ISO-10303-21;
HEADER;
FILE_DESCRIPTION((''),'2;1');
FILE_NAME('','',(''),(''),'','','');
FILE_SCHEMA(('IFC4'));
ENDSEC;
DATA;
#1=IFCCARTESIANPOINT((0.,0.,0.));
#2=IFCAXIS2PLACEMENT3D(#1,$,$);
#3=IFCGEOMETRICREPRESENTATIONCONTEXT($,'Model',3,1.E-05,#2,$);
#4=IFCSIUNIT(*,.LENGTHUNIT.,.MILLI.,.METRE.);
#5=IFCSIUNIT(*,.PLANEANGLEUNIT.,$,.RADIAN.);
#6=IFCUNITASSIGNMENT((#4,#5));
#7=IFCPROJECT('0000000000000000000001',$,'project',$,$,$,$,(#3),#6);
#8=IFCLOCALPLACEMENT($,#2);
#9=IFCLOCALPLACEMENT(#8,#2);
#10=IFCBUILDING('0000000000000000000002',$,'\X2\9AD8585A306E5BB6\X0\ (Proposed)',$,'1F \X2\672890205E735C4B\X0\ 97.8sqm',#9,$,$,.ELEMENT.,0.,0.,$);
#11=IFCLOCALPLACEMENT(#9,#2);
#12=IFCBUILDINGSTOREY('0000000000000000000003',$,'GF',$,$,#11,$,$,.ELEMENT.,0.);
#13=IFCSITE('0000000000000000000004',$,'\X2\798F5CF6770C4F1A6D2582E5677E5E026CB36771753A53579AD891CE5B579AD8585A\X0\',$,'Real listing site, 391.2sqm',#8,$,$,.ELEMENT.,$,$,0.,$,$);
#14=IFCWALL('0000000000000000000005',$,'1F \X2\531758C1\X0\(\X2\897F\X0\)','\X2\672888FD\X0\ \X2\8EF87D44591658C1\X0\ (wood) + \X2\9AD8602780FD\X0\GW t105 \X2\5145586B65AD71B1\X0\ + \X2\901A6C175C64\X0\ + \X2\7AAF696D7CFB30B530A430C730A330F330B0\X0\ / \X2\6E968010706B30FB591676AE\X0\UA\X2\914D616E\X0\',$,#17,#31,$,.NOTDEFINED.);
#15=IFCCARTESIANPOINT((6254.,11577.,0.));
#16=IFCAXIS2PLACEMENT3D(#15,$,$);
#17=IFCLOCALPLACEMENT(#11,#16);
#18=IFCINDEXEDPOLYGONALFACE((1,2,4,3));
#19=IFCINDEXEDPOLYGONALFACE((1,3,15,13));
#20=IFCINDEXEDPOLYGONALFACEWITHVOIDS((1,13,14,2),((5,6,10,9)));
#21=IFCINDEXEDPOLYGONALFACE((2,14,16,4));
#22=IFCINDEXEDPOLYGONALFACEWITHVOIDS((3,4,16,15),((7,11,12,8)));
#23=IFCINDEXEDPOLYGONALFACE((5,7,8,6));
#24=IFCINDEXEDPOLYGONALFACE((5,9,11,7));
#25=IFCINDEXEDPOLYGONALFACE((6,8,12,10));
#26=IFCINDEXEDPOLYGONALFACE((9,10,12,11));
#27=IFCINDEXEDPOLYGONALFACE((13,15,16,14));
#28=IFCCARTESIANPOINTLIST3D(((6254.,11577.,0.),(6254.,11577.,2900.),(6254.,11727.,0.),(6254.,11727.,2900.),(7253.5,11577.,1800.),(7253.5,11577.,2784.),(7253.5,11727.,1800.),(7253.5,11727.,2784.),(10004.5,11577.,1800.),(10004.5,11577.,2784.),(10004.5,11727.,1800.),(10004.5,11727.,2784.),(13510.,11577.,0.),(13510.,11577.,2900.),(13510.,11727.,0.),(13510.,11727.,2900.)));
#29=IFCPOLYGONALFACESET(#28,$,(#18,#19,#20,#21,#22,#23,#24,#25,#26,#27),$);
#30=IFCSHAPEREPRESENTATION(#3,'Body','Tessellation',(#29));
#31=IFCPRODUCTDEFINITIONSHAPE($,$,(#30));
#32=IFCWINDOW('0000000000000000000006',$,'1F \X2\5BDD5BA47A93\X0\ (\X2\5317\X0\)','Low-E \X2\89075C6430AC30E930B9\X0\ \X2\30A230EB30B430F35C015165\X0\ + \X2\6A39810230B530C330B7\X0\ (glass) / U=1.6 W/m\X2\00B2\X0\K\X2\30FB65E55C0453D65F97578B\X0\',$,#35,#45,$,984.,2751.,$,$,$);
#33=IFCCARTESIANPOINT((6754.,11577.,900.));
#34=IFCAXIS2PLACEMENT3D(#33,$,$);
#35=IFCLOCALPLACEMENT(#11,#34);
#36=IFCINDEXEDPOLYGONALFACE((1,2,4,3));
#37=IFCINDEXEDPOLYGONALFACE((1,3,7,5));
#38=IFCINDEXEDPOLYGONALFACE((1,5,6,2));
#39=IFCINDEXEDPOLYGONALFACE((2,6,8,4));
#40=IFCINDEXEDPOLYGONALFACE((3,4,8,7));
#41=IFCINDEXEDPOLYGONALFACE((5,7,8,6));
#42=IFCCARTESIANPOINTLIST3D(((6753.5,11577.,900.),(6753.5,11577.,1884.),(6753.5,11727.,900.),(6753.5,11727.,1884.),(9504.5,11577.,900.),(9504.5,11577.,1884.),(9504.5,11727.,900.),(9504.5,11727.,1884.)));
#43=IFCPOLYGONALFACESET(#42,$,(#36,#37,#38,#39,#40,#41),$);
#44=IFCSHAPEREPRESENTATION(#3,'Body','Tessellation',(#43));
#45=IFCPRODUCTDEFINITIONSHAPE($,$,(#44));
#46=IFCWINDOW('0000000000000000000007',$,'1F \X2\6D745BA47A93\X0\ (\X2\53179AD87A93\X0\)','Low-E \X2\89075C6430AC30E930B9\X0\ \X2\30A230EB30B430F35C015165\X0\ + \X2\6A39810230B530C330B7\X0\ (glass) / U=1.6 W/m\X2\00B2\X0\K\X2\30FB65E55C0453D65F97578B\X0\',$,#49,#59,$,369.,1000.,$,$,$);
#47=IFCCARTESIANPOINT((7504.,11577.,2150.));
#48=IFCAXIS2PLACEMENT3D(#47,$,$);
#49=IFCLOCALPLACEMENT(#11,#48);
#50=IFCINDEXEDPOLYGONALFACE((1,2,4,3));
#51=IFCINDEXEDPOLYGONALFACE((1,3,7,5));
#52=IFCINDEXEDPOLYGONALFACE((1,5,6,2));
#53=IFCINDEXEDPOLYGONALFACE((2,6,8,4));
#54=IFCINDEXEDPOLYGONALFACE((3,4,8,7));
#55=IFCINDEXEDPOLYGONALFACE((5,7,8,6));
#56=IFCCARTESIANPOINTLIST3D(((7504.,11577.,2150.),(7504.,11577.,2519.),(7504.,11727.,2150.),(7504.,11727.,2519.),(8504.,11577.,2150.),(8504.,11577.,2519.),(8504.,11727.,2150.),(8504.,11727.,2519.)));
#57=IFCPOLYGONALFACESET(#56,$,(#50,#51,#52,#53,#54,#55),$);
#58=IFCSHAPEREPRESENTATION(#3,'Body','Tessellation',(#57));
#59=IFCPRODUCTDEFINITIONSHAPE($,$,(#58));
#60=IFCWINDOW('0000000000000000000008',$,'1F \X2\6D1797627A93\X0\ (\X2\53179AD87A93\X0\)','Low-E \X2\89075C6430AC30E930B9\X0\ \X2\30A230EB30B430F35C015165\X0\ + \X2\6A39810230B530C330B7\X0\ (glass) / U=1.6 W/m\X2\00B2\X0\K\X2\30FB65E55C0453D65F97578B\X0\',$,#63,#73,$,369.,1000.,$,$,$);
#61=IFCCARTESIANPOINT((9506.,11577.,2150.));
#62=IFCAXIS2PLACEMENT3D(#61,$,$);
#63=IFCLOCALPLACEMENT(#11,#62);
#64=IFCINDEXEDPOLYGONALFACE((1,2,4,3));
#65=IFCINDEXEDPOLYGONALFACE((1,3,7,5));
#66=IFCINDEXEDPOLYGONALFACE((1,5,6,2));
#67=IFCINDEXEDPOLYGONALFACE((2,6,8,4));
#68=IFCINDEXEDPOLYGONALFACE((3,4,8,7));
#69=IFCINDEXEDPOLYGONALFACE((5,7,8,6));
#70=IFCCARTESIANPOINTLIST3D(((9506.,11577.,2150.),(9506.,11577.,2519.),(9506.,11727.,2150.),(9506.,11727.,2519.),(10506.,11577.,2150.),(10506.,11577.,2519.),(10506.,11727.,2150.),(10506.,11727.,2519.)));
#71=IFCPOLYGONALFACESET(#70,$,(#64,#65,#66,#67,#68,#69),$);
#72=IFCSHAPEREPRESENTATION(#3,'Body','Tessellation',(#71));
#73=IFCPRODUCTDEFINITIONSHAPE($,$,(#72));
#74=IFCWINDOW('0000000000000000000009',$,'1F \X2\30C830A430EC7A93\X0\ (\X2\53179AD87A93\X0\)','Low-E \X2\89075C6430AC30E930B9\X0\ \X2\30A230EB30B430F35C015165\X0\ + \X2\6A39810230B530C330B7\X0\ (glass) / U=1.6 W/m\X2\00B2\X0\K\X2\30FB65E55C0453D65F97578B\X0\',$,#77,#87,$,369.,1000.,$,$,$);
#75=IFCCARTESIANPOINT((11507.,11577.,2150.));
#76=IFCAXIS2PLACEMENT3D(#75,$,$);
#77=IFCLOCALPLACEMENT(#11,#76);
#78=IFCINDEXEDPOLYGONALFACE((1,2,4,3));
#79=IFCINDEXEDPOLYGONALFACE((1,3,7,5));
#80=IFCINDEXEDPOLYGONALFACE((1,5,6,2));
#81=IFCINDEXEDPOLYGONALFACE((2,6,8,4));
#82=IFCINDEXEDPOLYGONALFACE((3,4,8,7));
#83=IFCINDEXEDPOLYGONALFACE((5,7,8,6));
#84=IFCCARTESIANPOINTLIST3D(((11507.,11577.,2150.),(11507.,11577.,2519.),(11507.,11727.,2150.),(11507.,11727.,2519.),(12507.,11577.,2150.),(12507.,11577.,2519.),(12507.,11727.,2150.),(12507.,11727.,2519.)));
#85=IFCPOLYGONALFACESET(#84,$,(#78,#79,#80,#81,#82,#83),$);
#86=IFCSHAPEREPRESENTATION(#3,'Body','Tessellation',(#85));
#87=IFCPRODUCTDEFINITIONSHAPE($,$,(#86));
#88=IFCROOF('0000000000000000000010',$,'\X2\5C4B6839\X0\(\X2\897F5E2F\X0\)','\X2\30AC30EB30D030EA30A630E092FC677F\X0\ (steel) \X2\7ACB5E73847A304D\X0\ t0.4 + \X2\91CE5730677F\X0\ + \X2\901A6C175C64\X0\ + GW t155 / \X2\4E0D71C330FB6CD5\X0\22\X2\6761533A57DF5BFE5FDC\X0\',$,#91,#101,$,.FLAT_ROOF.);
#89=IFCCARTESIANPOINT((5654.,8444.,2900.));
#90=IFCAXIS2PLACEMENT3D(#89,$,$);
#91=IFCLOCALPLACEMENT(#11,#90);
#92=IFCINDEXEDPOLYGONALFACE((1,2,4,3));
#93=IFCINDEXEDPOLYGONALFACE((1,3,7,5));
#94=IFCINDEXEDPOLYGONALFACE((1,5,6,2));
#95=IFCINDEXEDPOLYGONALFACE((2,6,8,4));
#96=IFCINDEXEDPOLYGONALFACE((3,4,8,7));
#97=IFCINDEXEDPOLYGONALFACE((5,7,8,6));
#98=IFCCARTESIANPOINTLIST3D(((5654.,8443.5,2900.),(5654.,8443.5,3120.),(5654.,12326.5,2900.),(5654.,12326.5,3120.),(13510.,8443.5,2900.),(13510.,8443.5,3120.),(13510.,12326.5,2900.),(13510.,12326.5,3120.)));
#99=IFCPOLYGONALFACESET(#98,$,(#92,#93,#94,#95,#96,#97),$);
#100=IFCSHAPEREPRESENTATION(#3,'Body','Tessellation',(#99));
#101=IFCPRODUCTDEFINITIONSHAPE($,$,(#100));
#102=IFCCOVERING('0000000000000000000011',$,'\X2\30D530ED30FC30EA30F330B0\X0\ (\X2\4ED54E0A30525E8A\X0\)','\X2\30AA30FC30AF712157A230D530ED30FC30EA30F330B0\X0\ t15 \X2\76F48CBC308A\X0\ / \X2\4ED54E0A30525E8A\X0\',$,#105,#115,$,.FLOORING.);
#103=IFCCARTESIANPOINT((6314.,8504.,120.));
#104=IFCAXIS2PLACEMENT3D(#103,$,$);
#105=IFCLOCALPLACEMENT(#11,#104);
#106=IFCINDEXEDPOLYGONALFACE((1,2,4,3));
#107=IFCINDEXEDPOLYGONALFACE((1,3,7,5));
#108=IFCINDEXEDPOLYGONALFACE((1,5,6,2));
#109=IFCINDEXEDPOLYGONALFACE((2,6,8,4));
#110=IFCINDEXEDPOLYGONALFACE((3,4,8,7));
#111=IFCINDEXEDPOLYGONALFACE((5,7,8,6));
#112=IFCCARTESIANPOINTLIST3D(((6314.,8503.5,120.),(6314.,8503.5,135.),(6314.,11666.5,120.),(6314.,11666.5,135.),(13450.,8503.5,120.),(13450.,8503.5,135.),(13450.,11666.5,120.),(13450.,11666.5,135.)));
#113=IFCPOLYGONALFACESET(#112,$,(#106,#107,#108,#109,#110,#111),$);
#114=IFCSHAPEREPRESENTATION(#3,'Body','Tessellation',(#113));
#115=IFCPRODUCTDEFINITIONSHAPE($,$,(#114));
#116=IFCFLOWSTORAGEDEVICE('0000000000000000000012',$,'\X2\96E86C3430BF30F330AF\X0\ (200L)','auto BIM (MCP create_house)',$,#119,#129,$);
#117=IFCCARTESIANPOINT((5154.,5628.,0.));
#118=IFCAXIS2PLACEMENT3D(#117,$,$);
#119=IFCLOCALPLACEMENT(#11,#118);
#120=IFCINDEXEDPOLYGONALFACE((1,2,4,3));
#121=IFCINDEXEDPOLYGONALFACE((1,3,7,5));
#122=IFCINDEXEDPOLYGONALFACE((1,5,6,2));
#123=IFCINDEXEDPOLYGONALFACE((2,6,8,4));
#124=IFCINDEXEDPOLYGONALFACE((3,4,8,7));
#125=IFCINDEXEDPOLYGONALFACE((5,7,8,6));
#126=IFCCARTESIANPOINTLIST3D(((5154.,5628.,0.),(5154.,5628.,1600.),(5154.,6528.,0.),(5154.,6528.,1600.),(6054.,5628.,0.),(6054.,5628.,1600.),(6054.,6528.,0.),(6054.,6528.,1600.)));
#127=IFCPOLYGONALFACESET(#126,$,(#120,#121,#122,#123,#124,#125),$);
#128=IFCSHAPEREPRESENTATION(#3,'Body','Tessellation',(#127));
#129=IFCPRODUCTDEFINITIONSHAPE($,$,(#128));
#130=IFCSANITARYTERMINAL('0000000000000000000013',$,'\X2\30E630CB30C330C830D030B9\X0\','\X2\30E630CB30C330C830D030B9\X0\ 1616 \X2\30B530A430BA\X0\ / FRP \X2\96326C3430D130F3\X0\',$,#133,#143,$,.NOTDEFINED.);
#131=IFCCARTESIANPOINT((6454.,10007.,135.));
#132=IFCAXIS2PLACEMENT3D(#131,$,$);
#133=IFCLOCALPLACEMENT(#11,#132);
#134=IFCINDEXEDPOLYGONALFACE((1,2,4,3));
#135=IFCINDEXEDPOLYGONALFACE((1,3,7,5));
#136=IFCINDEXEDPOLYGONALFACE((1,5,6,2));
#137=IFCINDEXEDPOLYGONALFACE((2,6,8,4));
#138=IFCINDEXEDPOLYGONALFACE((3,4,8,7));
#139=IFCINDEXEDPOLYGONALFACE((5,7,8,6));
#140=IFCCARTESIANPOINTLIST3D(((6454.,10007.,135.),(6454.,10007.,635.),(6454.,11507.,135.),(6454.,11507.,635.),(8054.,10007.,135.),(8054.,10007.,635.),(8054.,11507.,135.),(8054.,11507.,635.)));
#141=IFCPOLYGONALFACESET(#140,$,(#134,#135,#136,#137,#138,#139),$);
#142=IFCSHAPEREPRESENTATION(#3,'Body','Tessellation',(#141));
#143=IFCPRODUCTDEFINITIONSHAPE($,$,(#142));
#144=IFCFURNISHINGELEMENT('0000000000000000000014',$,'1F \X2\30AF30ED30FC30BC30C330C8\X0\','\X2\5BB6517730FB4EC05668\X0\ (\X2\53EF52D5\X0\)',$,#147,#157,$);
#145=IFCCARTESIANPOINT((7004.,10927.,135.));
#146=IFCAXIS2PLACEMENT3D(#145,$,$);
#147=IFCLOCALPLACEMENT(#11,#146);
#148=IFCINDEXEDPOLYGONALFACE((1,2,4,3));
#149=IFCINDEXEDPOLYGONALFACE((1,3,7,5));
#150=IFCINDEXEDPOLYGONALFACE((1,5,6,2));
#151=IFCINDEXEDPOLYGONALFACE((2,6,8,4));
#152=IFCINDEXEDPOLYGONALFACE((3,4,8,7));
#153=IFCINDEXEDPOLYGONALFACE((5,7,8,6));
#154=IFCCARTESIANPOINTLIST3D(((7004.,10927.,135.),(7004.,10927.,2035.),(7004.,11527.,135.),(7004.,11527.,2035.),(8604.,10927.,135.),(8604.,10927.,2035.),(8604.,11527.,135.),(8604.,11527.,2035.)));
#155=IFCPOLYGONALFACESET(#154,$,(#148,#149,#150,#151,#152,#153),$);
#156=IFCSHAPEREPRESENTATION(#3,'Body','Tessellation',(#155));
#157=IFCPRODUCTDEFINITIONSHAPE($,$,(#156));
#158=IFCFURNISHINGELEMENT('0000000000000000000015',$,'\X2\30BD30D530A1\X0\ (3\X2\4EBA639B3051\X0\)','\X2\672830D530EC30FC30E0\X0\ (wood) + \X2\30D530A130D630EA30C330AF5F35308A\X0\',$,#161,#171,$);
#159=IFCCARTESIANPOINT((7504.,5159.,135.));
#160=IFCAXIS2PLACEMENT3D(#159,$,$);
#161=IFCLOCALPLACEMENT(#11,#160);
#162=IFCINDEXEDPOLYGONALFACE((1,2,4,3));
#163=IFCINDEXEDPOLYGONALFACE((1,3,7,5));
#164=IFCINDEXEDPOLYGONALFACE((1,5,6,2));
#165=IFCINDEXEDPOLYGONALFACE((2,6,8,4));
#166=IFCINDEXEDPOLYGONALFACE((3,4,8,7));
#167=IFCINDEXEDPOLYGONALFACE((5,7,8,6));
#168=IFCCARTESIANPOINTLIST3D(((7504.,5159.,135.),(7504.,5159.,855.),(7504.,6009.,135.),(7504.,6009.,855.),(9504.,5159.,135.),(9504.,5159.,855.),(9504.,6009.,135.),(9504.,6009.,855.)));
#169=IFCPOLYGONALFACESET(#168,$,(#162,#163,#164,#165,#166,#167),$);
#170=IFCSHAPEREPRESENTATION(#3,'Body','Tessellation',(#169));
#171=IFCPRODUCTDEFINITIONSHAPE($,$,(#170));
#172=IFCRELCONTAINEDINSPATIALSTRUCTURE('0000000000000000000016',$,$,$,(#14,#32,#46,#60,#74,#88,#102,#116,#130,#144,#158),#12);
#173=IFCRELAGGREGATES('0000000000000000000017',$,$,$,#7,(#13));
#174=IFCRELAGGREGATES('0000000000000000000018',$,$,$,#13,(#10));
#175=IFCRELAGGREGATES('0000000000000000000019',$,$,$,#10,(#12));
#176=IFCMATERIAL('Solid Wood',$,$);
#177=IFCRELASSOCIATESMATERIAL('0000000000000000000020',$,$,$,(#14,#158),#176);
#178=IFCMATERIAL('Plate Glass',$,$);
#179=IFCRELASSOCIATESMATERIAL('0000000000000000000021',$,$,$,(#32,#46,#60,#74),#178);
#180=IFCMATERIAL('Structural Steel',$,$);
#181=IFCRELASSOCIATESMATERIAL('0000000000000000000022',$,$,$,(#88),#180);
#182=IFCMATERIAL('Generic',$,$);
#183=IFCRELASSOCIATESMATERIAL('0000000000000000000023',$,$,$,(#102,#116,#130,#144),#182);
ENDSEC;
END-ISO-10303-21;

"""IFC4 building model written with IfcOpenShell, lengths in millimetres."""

from ifc_helpers import new_model, si_unit, frame, frame_2d, origin, place, context, project, spatial, rectangle, extrude, material, element, fill, save


model = new_model("IFC4")

# Units and contexts
model_context = context("Model", 3, precision=1e-05, world=origin())
ifc_project = project(units=[si_unit("LENGTHUNIT", "METRE", prefix="MILLI"), si_unit("PLANEANGLEUNIT", "RADIAN")], contexts=[model_context])

# Site, building, storey
site_placement = place(None, origin())
site = spatial("IfcSite", under=ifc_project, at=site_placement, Name="福島県会津若松市河東町南高野字高塚", ObjectType="Real listing site, 391.2sqm", CompositionType="ELEMENT", RefElevation=0.0)
building_placement = place(site_placement, origin())
building = spatial("IfcBuilding", under=site, at=building_placement, Name="高塚の家 (Proposed)", ObjectType="1F 木造平屋 97.8sqm", CompositionType="ELEMENT", ElevationOfRefHeight=0.0, ElevationOfTerrain=0.0)
storey_placement = place(building_placement, origin())
storey = spatial("IfcBuildingStorey", under=building, at=storey_placement, Name="GF", CompositionType="ELEMENT", Elevation=0.0)

# Shared definitions
ifc_material_1 = material(Name="Solid Wood")

# Shared definitions
ifc_material_2 = material(Name="Plate Glass")

# Wall, openings, windows
wall_1_placement = place(storey_placement, frame((6254.0, 11577.0, 0.0)))
wall_1 = element("IfcWall", 1, at=wall_1_placement, inside=storey, material=ifc_material_1, Name="1F 北壁(西)", Description="木製 軸組外壁 (wood) + 高性能GW t105 充填断熱 + 通気層 + 窯業系サイディング / 準耐火・外皮UA配慮", PredefinedType="NOTDEFINED", context=model_context, shape_type="SweptSolid", body=[
    extrude(rectangle(XDim=7256.0, YDim=150.0, at=frame_2d((3628.0, 75.0))), frame((6254.0, 11577.0, 0.0)), (0.0, 0.0, 1.0), 2900.0),
])
opening_1_placement = place(storey_placement, frame((6754.0, 11577.0, 900.0)))
opening_1 = element("IfcOpeningElement", 2, at=opening_1_placement, cuts=wall_1, PredefinedType="NOTDEFINED", context=model_context, shape_type="SweptSolid", body=[
    extrude(rectangle(XDim=2751.0, YDim=150.0, at=frame_2d((1375.0, 75.0))), frame((6754.0, 11577.0, 900.0)), (0.0, 0.0, 1.0), 984.0),
])
opening_2_placement = place(storey_placement, frame((7504.0, 11577.0, 2150.0)))
opening_2 = element("IfcOpeningElement", 3, at=opening_2_placement, cuts=wall_1, PredefinedType="NOTDEFINED", context=model_context, shape_type="SweptSolid", body=[
    extrude(rectangle(XDim=1000.0, YDim=150.0, at=frame_2d((500.0, 75.0))), frame((7504.0, 11577.0, 2150.0)), (0.0, 0.0, 1.0), 369.0),
])
opening_3_placement = place(storey_placement, frame((9506.0, 11577.0, 2150.0)))
opening_3 = element("IfcOpeningElement", 4, at=opening_3_placement, cuts=wall_1, PredefinedType="NOTDEFINED", context=model_context, shape_type="SweptSolid", body=[
    extrude(rectangle(XDim=1000.0, YDim=150.0, at=frame_2d((500.0, 75.0))), frame((9506.0, 11577.0, 2150.0)), (0.0, 0.0, 1.0), 369.0),
])
opening_4_placement = place(storey_placement, frame((11507.0, 11577.0, 2150.0)))
opening_4 = element("IfcOpeningElement", 5, at=opening_4_placement, cuts=wall_1, PredefinedType="NOTDEFINED", context=model_context, shape_type="SweptSolid", body=[
    extrude(rectangle(XDim=1000.0, YDim=150.0, at=frame_2d((500.0, 75.0))), frame((11507.0, 11577.0, 2150.0)), (0.0, 0.0, 1.0), 369.0),
])
window_1_placement = place(storey_placement, frame((6754.0, 11577.0, 900.0)))
window_1 = element("IfcWindow", 6, at=window_1_placement, inside=storey, material=ifc_material_2, Name="1F 寝室窓 (北)", Description="Low-E 複層ガラス アルゴン封入 + 樹脂サッシ (glass) / U=1.6 W/m²K・日射取得型", OverallHeight=984.0, OverallWidth=2751.0, context=model_context, shape_type="SweptSolid", body=[
    extrude(rectangle(XDim=2751.0, YDim=150.0, at=frame_2d((1375.0, 75.0))), frame((6754.0, 11577.0, 900.0)), (0.0, 0.0, 1.0), 984.0),
])
fill(opening_1, window_1)
window_2_placement = place(storey_placement, frame((7504.0, 11577.0, 2150.0)))
window_2 = element("IfcWindow", 7, at=window_2_placement, inside=storey, material=ifc_material_2, Name="1F 浴室窓 (北高窓)", Description="Low-E 複層ガラス アルゴン封入 + 樹脂サッシ (glass) / U=1.6 W/m²K・日射取得型", OverallHeight=369.0, OverallWidth=1000.0, context=model_context, shape_type="SweptSolid", body=[
    extrude(rectangle(XDim=1000.0, YDim=150.0, at=frame_2d((500.0, 75.0))), frame((7504.0, 11577.0, 2150.0)), (0.0, 0.0, 1.0), 369.0),
])
fill(opening_2, window_2)
window_3_placement = place(storey_placement, frame((9506.0, 11577.0, 2150.0)))
window_3 = element("IfcWindow", 8, at=window_3_placement, inside=storey, material=ifc_material_2, Name="1F 洗面窓 (北高窓)", Description="Low-E 複層ガラス アルゴン封入 + 樹脂サッシ (glass) / U=1.6 W/m²K・日射取得型", OverallHeight=369.0, OverallWidth=1000.0, context=model_context, shape_type="SweptSolid", body=[
    extrude(rectangle(XDim=1000.0, YDim=150.0, at=frame_2d((500.0, 75.0))), frame((9506.0, 11577.0, 2150.0)), (0.0, 0.0, 1.0), 369.0),
])
fill(opening_3, window_3)
window_4_placement = place(storey_placement, frame((11507.0, 11577.0, 2150.0)))
window_4 = element("IfcWindow", 9, at=window_4_placement, inside=storey, material=ifc_material_2, Name="1F トイレ窓 (北高窓)", Description="Low-E 複層ガラス アルゴン封入 + 樹脂サッシ (glass) / U=1.6 W/m²K・日射取得型", OverallHeight=369.0, OverallWidth=1000.0, context=model_context, shape_type="SweptSolid", body=[
    extrude(rectangle(XDim=1000.0, YDim=150.0, at=frame_2d((500.0, 75.0))), frame((11507.0, 11577.0, 2150.0)), (0.0, 0.0, 1.0), 369.0),
])
fill(opening_4, window_4)

# Roof
ifc_material_3 = material(Name="Structural Steel")
roof_1_placement = place(storey_placement, frame((5654.0, 8444.0, 2900.0)))
element("IfcRoof", 10, at=roof_1_placement, inside=storey, material=ifc_material_3, Name="屋根(西帯)", Description="ガルバリウム鋼板 (steel) 立平葺き t0.4 + 野地板 + 通気層 + GW t155 / 不燃・法22条区域対応", PredefinedType="FLAT_ROOF", context=model_context, shape_type="SweptSolid", body=[
    extrude(rectangle(XDim=7856.0, YDim=3883.0, at=frame_2d((3928.0, 1941.0))), frame((5654.0, 8444.0, 2900.0)), (0.0, 0.0, 1.0), 220.0),
])

# Covering
ifc_material_4 = material(Name="Generic")
covering_1_placement = place(storey_placement, frame((6314.0, 8504.0, 120.0)))
element("IfcCovering", 11, at=covering_1_placement, inside=storey, material=ifc_material_4, Name="フローリング (仕上げ床)", Description="オーク無垢フローリング t15 直貼り / 仕上げ床", PredefinedType="FLOORING", context=model_context, shape_type="SweptSolid", body=[
    extrude(rectangle(XDim=7136.0, YDim=3163.0, at=frame_2d((3568.0, 1581.0))), frame((6314.0, 8504.0, 120.0)), (0.0, 0.0, 1.0), 15.0),
])

# Flow storage device
flow_storage_device_placement = place(storey_placement, frame((5154.0, 5628.0, 0.0)))
element("IfcFlowStorageDevice", 12, at=flow_storage_device_placement, inside=storey, material=ifc_material_4, Name="雨水タンク (200L)", Description="auto BIM (MCP create_house)", context=model_context, shape_type="SweptSolid", body=[
    extrude(rectangle(XDim=900.0, YDim=900.0, at=frame_2d((450.0, 450.0))), frame((5154.0, 5628.0, 0.0)), (0.0, 0.0, 1.0), 1600.0),
])

# Sanitary terminal
sanitary_terminal_placement = place(storey_placement, frame((6454.0, 10007.0, 135.0)))
element("IfcSanitaryTerminal", 13, at=sanitary_terminal_placement, inside=storey, material=ifc_material_4, Name="ユニットバス", Description="ユニットバス 1616 サイズ / FRP 防水パン", PredefinedType="NOTDEFINED", context=model_context, shape_type="SweptSolid", body=[
    extrude(rectangle(XDim=1600.0, YDim=1500.0, at=frame_2d((800.0, 750.0))), frame((6454.0, 10007.0, 135.0)), (0.0, 0.0, 1.0), 500.0),
])

# Furnishing elements
furnishing_1_placement = place(storey_placement, frame((7004.0, 10927.0, 135.0)))
element("IfcFurnishingElement", 14, at=furnishing_1_placement, inside=storey, material=ifc_material_4, Name="1F クローゼット", Description="家具・什器 (可動)", context=model_context, shape_type="SweptSolid", body=[
    extrude(rectangle(XDim=1600.0, YDim=600.0, at=frame_2d((800.0, 300.0))), frame((7004.0, 10927.0, 135.0)), (0.0, 0.0, 1.0), 1900.0),
])
furnishing_2_placement = place(storey_placement, frame((7504.0, 5159.0, 135.0)))
element("IfcFurnishingElement", 15, at=furnishing_2_placement, inside=storey, material=ifc_material_1, Name="ソファ (3人掛け)", Description="木フレーム (wood) + ファブリック張り", context=model_context, shape_type="SweptSolid", body=[
    extrude(rectangle(XDim=2000.0, YDim=850.0, at=frame_2d((1000.0, 425.0))), frame((7504.0, 5159.0, 135.0)), (0.0, 0.0, 1.0), 720.0),
])

save(model, "model.ifc")
